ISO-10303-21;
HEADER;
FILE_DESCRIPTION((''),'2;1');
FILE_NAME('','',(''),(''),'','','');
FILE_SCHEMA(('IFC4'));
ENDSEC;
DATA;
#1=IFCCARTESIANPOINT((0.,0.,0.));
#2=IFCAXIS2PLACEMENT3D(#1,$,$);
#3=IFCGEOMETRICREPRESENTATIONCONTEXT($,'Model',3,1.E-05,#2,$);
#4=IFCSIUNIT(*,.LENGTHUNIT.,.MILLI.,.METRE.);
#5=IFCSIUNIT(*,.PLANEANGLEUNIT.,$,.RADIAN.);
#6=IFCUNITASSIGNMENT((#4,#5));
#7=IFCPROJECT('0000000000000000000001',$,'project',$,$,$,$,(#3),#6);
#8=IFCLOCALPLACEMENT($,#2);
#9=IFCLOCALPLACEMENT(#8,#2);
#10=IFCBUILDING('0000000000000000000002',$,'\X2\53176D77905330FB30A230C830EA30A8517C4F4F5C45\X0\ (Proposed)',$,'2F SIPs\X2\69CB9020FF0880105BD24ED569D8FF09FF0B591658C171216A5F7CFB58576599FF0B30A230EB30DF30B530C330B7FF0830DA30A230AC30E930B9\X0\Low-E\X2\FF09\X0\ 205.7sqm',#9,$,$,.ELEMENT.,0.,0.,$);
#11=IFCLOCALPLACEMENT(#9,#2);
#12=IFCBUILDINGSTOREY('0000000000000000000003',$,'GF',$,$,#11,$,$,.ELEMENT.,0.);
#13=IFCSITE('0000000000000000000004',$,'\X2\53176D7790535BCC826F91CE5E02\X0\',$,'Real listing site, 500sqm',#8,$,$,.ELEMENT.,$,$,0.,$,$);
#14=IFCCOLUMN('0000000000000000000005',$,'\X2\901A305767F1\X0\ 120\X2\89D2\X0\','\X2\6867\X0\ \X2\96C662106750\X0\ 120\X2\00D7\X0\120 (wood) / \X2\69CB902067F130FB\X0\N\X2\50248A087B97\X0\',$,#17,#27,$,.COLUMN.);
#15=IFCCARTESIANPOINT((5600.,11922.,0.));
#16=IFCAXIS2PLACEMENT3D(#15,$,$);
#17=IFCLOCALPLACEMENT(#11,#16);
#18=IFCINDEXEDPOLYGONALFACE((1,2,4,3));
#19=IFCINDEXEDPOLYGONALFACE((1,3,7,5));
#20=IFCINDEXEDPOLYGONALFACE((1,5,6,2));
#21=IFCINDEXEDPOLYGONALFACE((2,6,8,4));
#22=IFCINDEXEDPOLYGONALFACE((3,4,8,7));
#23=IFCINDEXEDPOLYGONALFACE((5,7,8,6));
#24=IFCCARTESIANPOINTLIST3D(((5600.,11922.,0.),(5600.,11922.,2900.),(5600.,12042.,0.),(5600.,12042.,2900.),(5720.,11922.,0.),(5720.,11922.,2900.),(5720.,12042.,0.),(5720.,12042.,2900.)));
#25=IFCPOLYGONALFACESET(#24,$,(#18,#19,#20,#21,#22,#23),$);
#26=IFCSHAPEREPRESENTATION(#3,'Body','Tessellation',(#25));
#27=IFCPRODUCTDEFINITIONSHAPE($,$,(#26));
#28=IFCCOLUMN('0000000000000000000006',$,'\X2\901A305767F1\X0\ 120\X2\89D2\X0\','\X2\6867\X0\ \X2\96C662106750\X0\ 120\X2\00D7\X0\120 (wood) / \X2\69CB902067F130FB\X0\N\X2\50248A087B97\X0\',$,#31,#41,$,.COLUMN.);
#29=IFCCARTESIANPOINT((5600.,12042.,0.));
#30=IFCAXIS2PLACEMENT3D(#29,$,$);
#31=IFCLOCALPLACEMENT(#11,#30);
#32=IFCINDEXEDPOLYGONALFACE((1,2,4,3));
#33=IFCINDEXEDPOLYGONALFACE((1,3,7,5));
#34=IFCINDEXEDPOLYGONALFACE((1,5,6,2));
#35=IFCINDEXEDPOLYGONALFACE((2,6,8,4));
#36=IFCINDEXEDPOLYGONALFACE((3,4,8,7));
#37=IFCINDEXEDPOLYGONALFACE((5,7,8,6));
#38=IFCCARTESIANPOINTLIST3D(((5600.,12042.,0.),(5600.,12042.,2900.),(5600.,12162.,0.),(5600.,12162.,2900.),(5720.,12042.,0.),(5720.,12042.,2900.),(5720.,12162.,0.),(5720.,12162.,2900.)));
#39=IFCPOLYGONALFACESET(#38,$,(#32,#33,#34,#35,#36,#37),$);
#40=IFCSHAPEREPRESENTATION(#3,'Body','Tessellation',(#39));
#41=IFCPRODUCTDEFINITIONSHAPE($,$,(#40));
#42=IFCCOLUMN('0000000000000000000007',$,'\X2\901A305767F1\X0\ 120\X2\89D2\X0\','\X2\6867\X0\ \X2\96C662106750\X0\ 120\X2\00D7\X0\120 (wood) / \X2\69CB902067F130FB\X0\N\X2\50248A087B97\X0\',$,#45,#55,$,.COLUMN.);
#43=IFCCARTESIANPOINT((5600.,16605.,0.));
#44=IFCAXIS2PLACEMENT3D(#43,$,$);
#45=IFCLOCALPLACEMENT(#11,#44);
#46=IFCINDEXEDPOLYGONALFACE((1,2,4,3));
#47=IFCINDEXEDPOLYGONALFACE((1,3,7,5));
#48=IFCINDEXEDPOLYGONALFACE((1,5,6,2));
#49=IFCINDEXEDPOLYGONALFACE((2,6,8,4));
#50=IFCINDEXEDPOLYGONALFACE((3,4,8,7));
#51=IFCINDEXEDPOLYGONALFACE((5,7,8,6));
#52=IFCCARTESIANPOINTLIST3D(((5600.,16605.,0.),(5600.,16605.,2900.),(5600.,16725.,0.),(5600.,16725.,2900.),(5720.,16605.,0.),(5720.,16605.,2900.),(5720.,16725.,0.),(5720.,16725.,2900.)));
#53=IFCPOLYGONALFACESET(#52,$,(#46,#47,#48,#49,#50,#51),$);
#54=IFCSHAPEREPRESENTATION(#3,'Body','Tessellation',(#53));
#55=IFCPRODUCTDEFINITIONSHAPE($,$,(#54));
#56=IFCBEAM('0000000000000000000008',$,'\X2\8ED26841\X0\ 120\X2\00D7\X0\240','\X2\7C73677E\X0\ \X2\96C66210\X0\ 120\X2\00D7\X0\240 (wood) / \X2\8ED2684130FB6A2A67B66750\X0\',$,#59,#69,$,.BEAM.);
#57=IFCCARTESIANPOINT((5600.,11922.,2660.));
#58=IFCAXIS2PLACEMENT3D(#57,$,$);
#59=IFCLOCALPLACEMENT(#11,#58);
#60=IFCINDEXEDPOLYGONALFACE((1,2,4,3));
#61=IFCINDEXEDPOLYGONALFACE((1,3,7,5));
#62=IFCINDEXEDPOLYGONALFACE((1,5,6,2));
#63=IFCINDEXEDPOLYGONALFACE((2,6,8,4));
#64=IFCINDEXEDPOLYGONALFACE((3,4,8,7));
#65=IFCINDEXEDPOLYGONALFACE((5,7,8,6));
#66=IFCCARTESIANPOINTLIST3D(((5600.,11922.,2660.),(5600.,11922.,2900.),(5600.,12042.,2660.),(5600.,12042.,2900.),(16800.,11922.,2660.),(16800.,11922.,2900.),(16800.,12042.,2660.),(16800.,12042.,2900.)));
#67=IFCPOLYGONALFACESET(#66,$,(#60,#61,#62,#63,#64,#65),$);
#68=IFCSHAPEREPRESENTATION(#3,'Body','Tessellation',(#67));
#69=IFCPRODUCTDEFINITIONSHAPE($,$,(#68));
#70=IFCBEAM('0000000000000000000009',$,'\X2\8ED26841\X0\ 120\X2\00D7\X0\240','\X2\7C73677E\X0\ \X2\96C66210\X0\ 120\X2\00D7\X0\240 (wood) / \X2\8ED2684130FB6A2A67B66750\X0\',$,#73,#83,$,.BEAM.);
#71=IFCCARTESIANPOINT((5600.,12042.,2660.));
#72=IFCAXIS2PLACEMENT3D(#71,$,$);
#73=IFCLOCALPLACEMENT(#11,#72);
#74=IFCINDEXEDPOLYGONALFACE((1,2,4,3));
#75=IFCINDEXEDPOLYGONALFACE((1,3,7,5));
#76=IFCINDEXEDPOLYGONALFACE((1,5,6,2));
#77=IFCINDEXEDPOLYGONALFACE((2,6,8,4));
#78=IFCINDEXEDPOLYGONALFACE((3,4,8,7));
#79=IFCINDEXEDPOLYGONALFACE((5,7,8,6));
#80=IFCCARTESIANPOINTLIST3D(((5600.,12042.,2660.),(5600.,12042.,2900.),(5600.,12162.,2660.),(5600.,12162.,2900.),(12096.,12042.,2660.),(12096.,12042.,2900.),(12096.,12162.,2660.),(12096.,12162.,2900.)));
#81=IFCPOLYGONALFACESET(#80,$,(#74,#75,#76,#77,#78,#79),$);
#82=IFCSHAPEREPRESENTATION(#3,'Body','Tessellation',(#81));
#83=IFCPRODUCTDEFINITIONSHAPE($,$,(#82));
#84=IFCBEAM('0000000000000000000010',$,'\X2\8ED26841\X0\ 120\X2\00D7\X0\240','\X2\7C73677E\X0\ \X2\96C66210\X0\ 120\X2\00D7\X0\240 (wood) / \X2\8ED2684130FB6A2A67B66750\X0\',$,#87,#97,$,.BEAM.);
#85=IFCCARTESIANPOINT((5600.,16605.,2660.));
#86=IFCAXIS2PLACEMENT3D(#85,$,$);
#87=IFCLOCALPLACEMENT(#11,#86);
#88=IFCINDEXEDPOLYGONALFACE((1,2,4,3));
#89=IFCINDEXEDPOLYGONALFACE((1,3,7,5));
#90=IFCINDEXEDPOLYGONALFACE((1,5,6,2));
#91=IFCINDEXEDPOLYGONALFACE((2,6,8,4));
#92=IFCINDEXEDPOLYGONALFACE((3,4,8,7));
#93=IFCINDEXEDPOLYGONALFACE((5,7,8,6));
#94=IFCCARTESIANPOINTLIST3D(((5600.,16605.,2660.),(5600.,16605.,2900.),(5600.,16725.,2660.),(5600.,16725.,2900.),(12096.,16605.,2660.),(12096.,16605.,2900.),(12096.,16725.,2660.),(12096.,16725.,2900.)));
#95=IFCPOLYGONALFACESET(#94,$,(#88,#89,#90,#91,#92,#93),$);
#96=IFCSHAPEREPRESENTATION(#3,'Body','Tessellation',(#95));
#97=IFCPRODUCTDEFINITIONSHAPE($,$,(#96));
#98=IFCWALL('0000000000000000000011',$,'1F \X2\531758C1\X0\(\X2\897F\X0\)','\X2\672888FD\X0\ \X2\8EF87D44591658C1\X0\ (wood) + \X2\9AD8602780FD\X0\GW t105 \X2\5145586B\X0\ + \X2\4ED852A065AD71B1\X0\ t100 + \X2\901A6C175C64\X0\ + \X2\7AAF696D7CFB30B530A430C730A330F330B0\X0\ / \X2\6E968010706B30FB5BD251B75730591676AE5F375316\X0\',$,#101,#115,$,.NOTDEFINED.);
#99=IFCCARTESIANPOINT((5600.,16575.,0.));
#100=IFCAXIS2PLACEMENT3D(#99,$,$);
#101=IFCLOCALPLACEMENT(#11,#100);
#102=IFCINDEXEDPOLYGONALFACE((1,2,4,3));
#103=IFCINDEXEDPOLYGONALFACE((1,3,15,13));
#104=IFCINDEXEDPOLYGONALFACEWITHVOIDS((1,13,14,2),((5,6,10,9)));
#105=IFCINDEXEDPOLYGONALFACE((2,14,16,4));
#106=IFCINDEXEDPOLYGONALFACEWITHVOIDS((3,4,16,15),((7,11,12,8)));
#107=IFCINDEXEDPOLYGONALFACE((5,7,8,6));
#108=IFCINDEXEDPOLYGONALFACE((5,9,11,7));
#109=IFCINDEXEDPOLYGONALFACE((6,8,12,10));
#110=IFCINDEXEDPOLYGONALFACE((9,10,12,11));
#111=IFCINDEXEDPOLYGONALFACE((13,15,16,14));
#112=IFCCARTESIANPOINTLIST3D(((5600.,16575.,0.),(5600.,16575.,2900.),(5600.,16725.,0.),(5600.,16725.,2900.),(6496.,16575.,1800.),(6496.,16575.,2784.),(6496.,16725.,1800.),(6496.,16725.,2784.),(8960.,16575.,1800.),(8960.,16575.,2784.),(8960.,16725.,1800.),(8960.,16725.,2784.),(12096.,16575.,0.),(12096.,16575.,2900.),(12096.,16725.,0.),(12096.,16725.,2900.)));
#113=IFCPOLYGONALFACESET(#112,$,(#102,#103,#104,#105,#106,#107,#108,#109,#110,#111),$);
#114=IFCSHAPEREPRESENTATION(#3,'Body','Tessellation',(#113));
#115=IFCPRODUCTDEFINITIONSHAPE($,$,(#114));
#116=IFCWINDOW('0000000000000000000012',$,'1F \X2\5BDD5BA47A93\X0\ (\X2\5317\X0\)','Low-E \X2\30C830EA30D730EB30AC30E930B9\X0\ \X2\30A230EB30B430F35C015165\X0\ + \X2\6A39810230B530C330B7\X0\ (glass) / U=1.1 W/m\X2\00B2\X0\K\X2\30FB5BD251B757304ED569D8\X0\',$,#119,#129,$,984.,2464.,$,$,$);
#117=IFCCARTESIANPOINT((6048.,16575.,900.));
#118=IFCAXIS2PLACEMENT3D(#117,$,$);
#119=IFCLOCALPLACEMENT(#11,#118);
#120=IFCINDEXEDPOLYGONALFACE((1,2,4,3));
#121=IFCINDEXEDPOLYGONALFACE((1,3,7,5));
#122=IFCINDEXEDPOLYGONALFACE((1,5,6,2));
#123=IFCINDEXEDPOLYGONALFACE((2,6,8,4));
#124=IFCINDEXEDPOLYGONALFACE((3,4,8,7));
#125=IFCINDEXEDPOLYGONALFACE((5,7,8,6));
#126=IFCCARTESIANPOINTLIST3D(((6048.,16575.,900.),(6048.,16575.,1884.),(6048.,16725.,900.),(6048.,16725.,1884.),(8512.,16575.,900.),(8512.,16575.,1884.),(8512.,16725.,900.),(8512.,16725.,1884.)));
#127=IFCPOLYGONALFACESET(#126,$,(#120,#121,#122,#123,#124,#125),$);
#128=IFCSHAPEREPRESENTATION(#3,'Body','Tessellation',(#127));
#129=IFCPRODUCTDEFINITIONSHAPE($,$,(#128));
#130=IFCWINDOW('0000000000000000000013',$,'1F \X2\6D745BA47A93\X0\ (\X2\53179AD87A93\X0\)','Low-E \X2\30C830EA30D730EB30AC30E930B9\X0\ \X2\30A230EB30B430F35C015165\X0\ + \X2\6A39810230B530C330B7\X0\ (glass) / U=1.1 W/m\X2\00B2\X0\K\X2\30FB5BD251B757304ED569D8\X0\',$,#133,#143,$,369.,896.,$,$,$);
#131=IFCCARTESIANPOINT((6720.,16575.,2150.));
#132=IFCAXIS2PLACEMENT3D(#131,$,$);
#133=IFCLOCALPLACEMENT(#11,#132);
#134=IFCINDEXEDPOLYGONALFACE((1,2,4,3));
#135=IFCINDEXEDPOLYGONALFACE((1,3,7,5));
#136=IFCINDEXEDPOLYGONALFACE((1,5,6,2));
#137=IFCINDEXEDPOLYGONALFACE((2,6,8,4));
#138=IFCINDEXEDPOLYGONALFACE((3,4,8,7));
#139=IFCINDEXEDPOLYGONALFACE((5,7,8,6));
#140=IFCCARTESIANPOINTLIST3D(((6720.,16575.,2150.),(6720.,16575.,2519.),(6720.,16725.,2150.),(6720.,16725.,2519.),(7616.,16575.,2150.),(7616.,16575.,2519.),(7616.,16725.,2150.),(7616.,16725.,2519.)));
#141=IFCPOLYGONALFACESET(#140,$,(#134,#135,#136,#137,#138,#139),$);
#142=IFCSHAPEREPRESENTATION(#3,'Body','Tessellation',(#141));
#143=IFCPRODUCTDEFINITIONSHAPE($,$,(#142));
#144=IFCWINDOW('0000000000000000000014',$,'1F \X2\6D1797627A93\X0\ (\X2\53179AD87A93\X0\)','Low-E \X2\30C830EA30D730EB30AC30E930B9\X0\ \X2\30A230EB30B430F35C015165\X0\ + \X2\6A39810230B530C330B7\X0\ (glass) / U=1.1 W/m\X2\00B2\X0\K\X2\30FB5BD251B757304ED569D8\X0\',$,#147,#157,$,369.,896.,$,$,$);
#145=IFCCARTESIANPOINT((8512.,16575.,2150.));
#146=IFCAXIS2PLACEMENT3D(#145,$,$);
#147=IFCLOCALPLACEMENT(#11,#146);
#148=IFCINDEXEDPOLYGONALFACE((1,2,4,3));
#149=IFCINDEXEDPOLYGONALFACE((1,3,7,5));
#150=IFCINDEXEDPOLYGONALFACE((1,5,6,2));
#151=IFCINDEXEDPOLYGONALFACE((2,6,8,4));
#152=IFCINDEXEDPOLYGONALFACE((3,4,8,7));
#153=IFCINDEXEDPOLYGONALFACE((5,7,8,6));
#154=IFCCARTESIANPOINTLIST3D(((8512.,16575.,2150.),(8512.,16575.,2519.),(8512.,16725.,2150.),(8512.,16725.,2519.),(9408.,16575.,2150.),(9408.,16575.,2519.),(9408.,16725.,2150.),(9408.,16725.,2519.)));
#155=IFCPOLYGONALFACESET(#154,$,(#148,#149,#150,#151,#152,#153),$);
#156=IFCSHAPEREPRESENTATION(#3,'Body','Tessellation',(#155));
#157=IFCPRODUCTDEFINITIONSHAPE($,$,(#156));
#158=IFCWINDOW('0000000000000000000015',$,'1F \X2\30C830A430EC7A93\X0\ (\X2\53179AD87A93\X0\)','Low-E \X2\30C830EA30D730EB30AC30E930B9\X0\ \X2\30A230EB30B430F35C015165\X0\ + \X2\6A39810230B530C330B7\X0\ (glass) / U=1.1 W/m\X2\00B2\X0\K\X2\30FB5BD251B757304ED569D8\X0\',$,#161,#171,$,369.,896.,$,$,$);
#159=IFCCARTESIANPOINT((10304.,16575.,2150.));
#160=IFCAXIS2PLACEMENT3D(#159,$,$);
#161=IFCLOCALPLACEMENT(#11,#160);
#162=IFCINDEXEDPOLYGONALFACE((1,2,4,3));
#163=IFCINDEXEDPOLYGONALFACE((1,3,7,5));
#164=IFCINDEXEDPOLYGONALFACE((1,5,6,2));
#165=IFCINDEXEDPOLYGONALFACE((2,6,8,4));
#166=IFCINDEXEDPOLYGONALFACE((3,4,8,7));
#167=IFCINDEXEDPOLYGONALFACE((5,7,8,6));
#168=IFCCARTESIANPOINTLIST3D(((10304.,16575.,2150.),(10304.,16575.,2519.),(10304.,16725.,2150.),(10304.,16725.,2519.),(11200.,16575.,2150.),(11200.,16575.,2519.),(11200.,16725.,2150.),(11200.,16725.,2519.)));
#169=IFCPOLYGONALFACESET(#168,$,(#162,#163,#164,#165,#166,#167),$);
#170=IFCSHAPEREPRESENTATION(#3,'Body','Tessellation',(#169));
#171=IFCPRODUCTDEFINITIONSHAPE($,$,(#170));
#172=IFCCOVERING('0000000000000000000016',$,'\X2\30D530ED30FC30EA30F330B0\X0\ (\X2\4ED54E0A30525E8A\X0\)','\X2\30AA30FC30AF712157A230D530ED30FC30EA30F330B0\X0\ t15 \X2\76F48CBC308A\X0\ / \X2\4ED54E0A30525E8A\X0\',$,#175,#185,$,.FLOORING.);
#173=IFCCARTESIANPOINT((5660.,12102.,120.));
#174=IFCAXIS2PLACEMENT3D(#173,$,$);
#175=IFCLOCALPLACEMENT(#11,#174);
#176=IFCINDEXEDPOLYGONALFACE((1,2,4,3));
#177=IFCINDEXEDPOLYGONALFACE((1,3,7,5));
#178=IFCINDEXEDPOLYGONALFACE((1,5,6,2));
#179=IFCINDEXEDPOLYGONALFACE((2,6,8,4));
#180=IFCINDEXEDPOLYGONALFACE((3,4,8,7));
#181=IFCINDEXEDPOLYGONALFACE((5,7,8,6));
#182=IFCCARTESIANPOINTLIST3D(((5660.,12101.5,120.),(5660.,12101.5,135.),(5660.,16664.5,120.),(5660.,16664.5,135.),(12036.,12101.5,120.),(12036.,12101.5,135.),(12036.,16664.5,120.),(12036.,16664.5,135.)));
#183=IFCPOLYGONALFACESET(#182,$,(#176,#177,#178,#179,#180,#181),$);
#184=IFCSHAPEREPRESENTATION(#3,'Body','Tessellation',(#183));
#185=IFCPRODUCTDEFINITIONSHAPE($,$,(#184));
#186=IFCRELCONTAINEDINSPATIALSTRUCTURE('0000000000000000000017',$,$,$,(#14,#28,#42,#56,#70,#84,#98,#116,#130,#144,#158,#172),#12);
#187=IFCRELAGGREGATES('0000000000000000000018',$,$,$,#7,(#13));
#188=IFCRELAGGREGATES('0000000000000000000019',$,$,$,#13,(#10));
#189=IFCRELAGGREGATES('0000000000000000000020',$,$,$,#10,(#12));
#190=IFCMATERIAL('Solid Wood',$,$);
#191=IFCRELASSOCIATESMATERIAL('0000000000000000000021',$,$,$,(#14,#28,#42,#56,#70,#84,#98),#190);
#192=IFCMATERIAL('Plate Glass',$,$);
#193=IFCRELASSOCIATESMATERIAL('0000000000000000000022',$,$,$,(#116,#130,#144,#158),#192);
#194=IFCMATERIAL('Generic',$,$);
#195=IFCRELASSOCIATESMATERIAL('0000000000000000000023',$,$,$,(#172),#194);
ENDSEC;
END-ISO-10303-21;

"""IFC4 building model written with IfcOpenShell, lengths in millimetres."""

from ifc_helpers import new_model, si_unit, frame, frame_2d, origin, place, context, project, spatial, rectangle, extrude, material, element, fill, save


model = new_model("IFC4")

# Units and contexts
model_context = context("Model", 3, precision=1e-05, world=origin())
ifc_project = project(units=[si_unit("LENGTHUNIT", "METRE", prefix="MILLI"), si_unit("PLANEANGLEUNIT", "RADIAN")], contexts=[model_context])

# Site, building, storey
site_placement = place(None, origin())
site = spatial("IfcSite", under=ifc_project, at=site_placement, Name="北海道富良野市", ObjectType="Real listing site, 500sqm", CompositionType="ELEMENT", RefElevation=0.0)
building_placement = place(site_placement, origin())
building = spatial("IfcBuilding", under=site, at=building_placement, Name="北海道・アトリエ兼住居 (Proposed)", ObjectType="2F SIPs構造（耐寒仕様）＋外壁無機系塗料＋アルミサッシ（ペアガラスLow-E） 205.7sqm", CompositionType="ELEMENT", ElevationOfRefHeight=0.0, ElevationOfTerrain=0.0)
storey_placement = place(building_placement, origin())
storey = spatial("IfcBuildingStorey", under=building, at=storey_placement, Name="GF", CompositionType="ELEMENT", Elevation=0.0)

# Columns
ifc_material_1 = material(Name="Solid Wood")
column_1_placement = place(storey_placement, frame((5600.0, 11922.0, 0.0)))
element("IfcColumn", 1, at=column_1_placement, inside=storey, material=ifc_material_1, Name="通し柱 120角", Description="桧 集成材 120×120 (wood) / 構造柱・N値計算", PredefinedType="COLUMN", context=model_context, shape_type="SweptSolid", body=[
    extrude(rectangle(XDim=120.0, YDim=120.0, at=frame_2d((60.0, 60.0))), frame((5600.0, 11922.0, 0.0)), (0.0, 0.0, 1.0), 2900.0),
])
column_2_placement = place(storey_placement, frame((5600.0, 12042.0, 0.0)))
element("IfcColumn", 2, at=column_2_placement, inside=storey, material=ifc_material_1, Name="通し柱 120角", Description="桧 集成材 120×120 (wood) / 構造柱・N値計算", PredefinedType="COLUMN", context=model_context, shape_type="SweptSolid", body=[
    extrude(rectangle(XDim=120.0, YDim=120.0, at=frame_2d((60.0, 60.0))), frame((5600.0, 12042.0, 0.0)), (0.0, 0.0, 1.0), 2900.0),
])
column_3_placement = place(storey_placement, frame((5600.0, 16605.0, 0.0)))
element("IfcColumn", 3, at=column_3_placement, inside=storey, material=ifc_material_1, Name="通し柱 120角", Description="桧 集成材 120×120 (wood) / 構造柱・N値計算", PredefinedType="COLUMN", context=model_context, shape_type="SweptSolid", body=[
    extrude(rectangle(XDim=120.0, YDim=120.0, at=frame_2d((60.0, 60.0))), frame((5600.0, 16605.0, 0.0)), (0.0, 0.0, 1.0), 2900.0),
])

# Beams
beam_1_placement = place(storey_placement, frame((5600.0, 11922.0, 2660.0)))
element("IfcBeam", 4, at=beam_1_placement, inside=storey, material=ifc_material_1, Name="軒桁 120×240", Description="米松 集成 120×240 (wood) / 軒桁・横架材", PredefinedType="BEAM", context=model_context, shape_type="SweptSolid", body=[
    extrude(rectangle(XDim=11200.0, YDim=120.0, at=frame_2d((5600.0, 60.0))), frame((5600.0, 11922.0, 2660.0)), (0.0, 0.0, 1.0), 240.0),
])
beam_2_placement = place(storey_placement, frame((5600.0, 12042.0, 2660.0)))
element("IfcBeam", 5, at=beam_2_placement, inside=storey, material=ifc_material_1, Name="軒桁 120×240", Description="米松 集成 120×240 (wood) / 軒桁・横架材", PredefinedType="BEAM", context=model_context, shape_type="SweptSolid", body=[
    extrude(rectangle(XDim=6496.0, YDim=120.0, at=frame_2d((3248.0, 60.0))), frame((5600.0, 12042.0, 2660.0)), (0.0, 0.0, 1.0), 240.0),
])
beam_3_placement = place(storey_placement, frame((5600.0, 16605.0, 2660.0)))
element("IfcBeam", 6, at=beam_3_placement, inside=storey, material=ifc_material_1, Name="軒桁 120×240", Description="米松 集成 120×240 (wood) / 軒桁・横架材", PredefinedType="BEAM", context=model_context, shape_type="SweptSolid", body=[
    extrude(rectangle(XDim=6496.0, YDim=120.0, at=frame_2d((3248.0, 60.0))), frame((5600.0, 16605.0, 2660.0)), (0.0, 0.0, 1.0), 240.0),
])

# Wall, openings, windows
wall_1_placement = place(storey_placement, frame((5600.0, 16575.0, 0.0)))
wall_1 = element("IfcWall", 7, at=wall_1_placement, inside=storey, material=ifc_material_1, Name="1F 北壁(西)", Description="木製 軸組外壁 (wood) + 高性能GW t105 充填 + 付加断熱 t100 + 通気層 + 窯業系サイディング / 準耐火・寒冷地外皮強化", PredefinedType="NOTDEFINED", context=model_context, shape_type="SweptSolid", body=[
    extrude(rectangle(XDim=6496.0, YDim=150.0, at=frame_2d((3248.0, 75.0))), frame((5600.0, 16575.0, 0.0)), (0.0, 0.0, 1.0), 2900.0),
])
opening_1_placement = place(storey_placement, frame((6048.0, 16575.0, 900.0)))
opening_1 = element("IfcOpeningElement", 8, at=opening_1_placement, cuts=wall_1, PredefinedType="NOTDEFINED", context=model_context, shape_type="SweptSolid", body=[
    extrude(rectangle(XDim=2464.0, YDim=150.0, at=frame_2d((1232.0, 75.0))), frame((6048.0, 16575.0, 900.0)), (0.0, 0.0, 1.0), 984.0),
])
opening_2_placement = place(storey_placement, frame((6720.0, 16575.0, 2150.0)))
opening_2 = element("IfcOpeningElement", 9, at=opening_2_placement, cuts=wall_1, PredefinedType="NOTDEFINED", context=model_context, shape_type="SweptSolid", body=[
    extrude(rectangle(XDim=896.0, YDim=150.0, at=frame_2d((448.0, 75.0))), frame((6720.0, 16575.0, 2150.0)), (0.0, 0.0, 1.0), 369.0),
])
opening_3_placement = place(storey_placement, frame((8512.0, 16575.0, 2150.0)))
opening_3 = element("IfcOpeningElement", 10, at=opening_3_placement, cuts=wall_1, PredefinedType="NOTDEFINED", context=model_context, shape_type="SweptSolid", body=[
    extrude(rectangle(XDim=896.0, YDim=150.0, at=frame_2d((448.0, 75.0))), frame((8512.0, 16575.0, 2150.0)), (0.0, 0.0, 1.0), 369.0),
])
opening_4_placement = place(storey_placement, frame((10304.0, 16575.0, 2150.0)))
opening_4 = element("IfcOpeningElement", 11, at=opening_4_placement, cuts=wall_1, PredefinedType="NOTDEFINED", context=model_context, shape_type="SweptSolid", body=[
    extrude(rectangle(XDim=896.0, YDim=150.0, at=frame_2d((448.0, 75.0))), frame((10304.0, 16575.0, 2150.0)), (0.0, 0.0, 1.0), 369.0),
])
ifc_material_2 = material(Name="Plate Glass")
window_1_placement = place(storey_placement, frame((6048.0, 16575.0, 900.0)))
window_1 = element("IfcWindow", 12, at=window_1_placement, inside=storey, material=ifc_material_2, Name="1F 寝室窓 (北)", Description="Low-E トリプルガラス アルゴン封入 + 樹脂サッシ (glass) / U=1.1 W/m²K・寒冷地仕様", OverallHeight=984.0, OverallWidth=2464.0, context=model_context, shape_type="SweptSolid", body=[
    extrude(rectangle(XDim=2464.0, YDim=150.0, at=frame_2d((1232.0, 75.0))), frame((6048.0, 16575.0, 900.0)), (0.0, 0.0, 1.0), 984.0),
])
fill(opening_1, window_1)
window_2_placement = place(storey_placement, frame((6720.0, 16575.0, 2150.0)))
window_2 = element("IfcWindow", 13, at=window_2_placement, inside=storey, material=ifc_material_2, Name="1F 浴室窓 (北高窓)", Description="Low-E トリプルガラス アルゴン封入 + 樹脂サッシ (glass) / U=1.1 W/m²K・寒冷地仕様", OverallHeight=369.0, OverallWidth=896.0, context=model_context, shape_type="SweptSolid", body=[
    extrude(rectangle(XDim=896.0, YDim=150.0, at=frame_2d((448.0, 75.0))), frame((6720.0, 16575.0, 2150.0)), (0.0, 0.0, 1.0), 369.0),
])
fill(opening_2, window_2)
window_3_placement = place(storey_placement, frame((8512.0, 16575.0, 2150.0)))
window_3 = element("IfcWindow", 14, at=window_3_placement, inside=storey, material=ifc_material_2, Name="1F 洗面窓 (北高窓)", Description="Low-E トリプルガラス アルゴン封入 + 樹脂サッシ (glass) / U=1.1 W/m²K・寒冷地仕様", OverallHeight=369.0, OverallWidth=896.0, context=model_context, shape_type="SweptSolid", body=[
    extrude(rectangle(XDim=896.0, YDim=150.0, at=frame_2d((448.0, 75.0))), frame((8512.0, 16575.0, 2150.0)), (0.0, 0.0, 1.0), 369.0),
])
fill(opening_3, window_3)
window_4_placement = place(storey_placement, frame((10304.0, 16575.0, 2150.0)))
window_4 = element("IfcWindow", 15, at=window_4_placement, inside=storey, material=ifc_material_2, Name="1F トイレ窓 (北高窓)", Description="Low-E トリプルガラス アルゴン封入 + 樹脂サッシ (glass) / U=1.1 W/m²K・寒冷地仕様", OverallHeight=369.0, OverallWidth=896.0, context=model_context, shape_type="SweptSolid", body=[
    extrude(rectangle(XDim=896.0, YDim=150.0, at=frame_2d((448.0, 75.0))), frame((10304.0, 16575.0, 2150.0)), (0.0, 0.0, 1.0), 369.0),
])
fill(opening_4, window_4)

# Covering
ifc_material_3 = material(Name="Generic")
covering_placement = place(storey_placement, frame((5660.0, 12102.0, 120.0)))
element("IfcCovering", 16, at=covering_placement, inside=storey, material=ifc_material_3, Name="フローリング (仕上げ床)", Description="オーク無垢フローリング t15 直貼り / 仕上げ床", PredefinedType="FLOORING", context=model_context, shape_type="SweptSolid", body=[
    extrude(rectangle(XDim=6376.0, YDim=4563.0, at=frame_2d((3188.0, 2281.0))), frame((5660.0, 12102.0, 120.0)), (0.0, 0.0, 1.0), 15.0),
])

save(model, "model.ifc")
